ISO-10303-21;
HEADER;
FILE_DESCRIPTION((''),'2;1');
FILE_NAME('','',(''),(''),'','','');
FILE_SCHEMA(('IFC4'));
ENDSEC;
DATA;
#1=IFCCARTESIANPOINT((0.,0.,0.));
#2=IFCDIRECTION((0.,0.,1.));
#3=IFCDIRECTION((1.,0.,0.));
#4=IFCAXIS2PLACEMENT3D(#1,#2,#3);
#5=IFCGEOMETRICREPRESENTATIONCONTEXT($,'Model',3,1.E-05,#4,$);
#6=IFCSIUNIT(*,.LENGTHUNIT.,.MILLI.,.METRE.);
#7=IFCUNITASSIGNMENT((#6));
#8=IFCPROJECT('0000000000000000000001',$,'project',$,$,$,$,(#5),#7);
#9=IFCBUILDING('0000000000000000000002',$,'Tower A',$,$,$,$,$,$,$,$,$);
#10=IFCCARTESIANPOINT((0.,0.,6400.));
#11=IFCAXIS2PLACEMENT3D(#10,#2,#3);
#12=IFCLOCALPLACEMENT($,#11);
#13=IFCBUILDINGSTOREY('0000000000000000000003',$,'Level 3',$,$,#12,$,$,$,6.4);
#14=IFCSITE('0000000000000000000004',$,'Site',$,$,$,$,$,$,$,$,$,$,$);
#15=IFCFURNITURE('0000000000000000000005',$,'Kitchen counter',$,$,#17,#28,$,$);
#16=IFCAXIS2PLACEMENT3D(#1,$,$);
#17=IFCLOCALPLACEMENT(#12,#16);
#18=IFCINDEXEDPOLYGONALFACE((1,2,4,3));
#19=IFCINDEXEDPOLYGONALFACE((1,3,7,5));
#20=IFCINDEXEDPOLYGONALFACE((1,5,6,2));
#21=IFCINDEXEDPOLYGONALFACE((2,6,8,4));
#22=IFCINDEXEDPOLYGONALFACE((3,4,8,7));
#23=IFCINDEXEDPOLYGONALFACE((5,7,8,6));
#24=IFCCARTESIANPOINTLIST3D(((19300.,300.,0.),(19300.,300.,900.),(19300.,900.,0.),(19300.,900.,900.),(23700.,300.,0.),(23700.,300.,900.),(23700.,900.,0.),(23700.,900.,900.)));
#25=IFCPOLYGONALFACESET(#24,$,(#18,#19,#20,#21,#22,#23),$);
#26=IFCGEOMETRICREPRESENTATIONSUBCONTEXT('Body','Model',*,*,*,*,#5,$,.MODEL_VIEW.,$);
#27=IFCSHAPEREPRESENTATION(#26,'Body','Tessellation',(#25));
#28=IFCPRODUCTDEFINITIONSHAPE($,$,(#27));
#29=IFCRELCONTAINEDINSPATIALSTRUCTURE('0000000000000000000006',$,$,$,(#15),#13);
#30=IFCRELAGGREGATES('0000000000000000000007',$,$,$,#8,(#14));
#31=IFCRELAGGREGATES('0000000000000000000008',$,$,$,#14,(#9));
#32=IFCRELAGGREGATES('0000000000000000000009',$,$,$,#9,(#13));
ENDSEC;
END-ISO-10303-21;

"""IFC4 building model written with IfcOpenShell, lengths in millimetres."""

from ifc_helpers import new_model, si_unit, frame, origin_with_axes, place, context, subcontext, project, spatial, indexed_curve, outline, extrude, element, save


model = new_model("IFC4")

# Units and contexts
model_context = context("Model", 3, precision=1e-05, world=origin_with_axes())
body_context = subcontext(model_context, "Body", "Model", "MODEL_VIEW")
ifc_project = project(units=[si_unit("LENGTHUNIT", "METRE", prefix="MILLI")], contexts=[model_context])

# Site, building, storey
site = spatial("IfcSite", under=ifc_project, Name="Site")
building = spatial("IfcBuilding", under=site, Name="Tower A")
storey_placement = place(None, frame((0.0, 0.0, 6400.0), z_axis=(0.0, 0.0, 1.0), x_axis=(1.0, 0.0, 0.0)))
storey = spatial("IfcBuildingStorey", under=building, at=storey_placement, Name="Level 3", Elevation=6.4)

# Furniture
furniture_1_placement = place(storey_placement, frame((19300.0, 300.0, 0.0), z_axis=(0.0, 0.0, 1.0), x_axis=(1.0, 0.0, 0.0)))
element("IfcFurniture", 1, at=furniture_1_placement, inside=storey, Name="Kitchen counter", context=body_context, shape_type="SweptSolid", body=[
    extrude(outline(indexed_curve([(0.0, 0.0), (4400.0, 0.0), (4400.0, 600.0), (0.0, 600.0)])), None, (0.0, 0.0, 1.0), 900.0),
])

save(model, "model.ifc")
